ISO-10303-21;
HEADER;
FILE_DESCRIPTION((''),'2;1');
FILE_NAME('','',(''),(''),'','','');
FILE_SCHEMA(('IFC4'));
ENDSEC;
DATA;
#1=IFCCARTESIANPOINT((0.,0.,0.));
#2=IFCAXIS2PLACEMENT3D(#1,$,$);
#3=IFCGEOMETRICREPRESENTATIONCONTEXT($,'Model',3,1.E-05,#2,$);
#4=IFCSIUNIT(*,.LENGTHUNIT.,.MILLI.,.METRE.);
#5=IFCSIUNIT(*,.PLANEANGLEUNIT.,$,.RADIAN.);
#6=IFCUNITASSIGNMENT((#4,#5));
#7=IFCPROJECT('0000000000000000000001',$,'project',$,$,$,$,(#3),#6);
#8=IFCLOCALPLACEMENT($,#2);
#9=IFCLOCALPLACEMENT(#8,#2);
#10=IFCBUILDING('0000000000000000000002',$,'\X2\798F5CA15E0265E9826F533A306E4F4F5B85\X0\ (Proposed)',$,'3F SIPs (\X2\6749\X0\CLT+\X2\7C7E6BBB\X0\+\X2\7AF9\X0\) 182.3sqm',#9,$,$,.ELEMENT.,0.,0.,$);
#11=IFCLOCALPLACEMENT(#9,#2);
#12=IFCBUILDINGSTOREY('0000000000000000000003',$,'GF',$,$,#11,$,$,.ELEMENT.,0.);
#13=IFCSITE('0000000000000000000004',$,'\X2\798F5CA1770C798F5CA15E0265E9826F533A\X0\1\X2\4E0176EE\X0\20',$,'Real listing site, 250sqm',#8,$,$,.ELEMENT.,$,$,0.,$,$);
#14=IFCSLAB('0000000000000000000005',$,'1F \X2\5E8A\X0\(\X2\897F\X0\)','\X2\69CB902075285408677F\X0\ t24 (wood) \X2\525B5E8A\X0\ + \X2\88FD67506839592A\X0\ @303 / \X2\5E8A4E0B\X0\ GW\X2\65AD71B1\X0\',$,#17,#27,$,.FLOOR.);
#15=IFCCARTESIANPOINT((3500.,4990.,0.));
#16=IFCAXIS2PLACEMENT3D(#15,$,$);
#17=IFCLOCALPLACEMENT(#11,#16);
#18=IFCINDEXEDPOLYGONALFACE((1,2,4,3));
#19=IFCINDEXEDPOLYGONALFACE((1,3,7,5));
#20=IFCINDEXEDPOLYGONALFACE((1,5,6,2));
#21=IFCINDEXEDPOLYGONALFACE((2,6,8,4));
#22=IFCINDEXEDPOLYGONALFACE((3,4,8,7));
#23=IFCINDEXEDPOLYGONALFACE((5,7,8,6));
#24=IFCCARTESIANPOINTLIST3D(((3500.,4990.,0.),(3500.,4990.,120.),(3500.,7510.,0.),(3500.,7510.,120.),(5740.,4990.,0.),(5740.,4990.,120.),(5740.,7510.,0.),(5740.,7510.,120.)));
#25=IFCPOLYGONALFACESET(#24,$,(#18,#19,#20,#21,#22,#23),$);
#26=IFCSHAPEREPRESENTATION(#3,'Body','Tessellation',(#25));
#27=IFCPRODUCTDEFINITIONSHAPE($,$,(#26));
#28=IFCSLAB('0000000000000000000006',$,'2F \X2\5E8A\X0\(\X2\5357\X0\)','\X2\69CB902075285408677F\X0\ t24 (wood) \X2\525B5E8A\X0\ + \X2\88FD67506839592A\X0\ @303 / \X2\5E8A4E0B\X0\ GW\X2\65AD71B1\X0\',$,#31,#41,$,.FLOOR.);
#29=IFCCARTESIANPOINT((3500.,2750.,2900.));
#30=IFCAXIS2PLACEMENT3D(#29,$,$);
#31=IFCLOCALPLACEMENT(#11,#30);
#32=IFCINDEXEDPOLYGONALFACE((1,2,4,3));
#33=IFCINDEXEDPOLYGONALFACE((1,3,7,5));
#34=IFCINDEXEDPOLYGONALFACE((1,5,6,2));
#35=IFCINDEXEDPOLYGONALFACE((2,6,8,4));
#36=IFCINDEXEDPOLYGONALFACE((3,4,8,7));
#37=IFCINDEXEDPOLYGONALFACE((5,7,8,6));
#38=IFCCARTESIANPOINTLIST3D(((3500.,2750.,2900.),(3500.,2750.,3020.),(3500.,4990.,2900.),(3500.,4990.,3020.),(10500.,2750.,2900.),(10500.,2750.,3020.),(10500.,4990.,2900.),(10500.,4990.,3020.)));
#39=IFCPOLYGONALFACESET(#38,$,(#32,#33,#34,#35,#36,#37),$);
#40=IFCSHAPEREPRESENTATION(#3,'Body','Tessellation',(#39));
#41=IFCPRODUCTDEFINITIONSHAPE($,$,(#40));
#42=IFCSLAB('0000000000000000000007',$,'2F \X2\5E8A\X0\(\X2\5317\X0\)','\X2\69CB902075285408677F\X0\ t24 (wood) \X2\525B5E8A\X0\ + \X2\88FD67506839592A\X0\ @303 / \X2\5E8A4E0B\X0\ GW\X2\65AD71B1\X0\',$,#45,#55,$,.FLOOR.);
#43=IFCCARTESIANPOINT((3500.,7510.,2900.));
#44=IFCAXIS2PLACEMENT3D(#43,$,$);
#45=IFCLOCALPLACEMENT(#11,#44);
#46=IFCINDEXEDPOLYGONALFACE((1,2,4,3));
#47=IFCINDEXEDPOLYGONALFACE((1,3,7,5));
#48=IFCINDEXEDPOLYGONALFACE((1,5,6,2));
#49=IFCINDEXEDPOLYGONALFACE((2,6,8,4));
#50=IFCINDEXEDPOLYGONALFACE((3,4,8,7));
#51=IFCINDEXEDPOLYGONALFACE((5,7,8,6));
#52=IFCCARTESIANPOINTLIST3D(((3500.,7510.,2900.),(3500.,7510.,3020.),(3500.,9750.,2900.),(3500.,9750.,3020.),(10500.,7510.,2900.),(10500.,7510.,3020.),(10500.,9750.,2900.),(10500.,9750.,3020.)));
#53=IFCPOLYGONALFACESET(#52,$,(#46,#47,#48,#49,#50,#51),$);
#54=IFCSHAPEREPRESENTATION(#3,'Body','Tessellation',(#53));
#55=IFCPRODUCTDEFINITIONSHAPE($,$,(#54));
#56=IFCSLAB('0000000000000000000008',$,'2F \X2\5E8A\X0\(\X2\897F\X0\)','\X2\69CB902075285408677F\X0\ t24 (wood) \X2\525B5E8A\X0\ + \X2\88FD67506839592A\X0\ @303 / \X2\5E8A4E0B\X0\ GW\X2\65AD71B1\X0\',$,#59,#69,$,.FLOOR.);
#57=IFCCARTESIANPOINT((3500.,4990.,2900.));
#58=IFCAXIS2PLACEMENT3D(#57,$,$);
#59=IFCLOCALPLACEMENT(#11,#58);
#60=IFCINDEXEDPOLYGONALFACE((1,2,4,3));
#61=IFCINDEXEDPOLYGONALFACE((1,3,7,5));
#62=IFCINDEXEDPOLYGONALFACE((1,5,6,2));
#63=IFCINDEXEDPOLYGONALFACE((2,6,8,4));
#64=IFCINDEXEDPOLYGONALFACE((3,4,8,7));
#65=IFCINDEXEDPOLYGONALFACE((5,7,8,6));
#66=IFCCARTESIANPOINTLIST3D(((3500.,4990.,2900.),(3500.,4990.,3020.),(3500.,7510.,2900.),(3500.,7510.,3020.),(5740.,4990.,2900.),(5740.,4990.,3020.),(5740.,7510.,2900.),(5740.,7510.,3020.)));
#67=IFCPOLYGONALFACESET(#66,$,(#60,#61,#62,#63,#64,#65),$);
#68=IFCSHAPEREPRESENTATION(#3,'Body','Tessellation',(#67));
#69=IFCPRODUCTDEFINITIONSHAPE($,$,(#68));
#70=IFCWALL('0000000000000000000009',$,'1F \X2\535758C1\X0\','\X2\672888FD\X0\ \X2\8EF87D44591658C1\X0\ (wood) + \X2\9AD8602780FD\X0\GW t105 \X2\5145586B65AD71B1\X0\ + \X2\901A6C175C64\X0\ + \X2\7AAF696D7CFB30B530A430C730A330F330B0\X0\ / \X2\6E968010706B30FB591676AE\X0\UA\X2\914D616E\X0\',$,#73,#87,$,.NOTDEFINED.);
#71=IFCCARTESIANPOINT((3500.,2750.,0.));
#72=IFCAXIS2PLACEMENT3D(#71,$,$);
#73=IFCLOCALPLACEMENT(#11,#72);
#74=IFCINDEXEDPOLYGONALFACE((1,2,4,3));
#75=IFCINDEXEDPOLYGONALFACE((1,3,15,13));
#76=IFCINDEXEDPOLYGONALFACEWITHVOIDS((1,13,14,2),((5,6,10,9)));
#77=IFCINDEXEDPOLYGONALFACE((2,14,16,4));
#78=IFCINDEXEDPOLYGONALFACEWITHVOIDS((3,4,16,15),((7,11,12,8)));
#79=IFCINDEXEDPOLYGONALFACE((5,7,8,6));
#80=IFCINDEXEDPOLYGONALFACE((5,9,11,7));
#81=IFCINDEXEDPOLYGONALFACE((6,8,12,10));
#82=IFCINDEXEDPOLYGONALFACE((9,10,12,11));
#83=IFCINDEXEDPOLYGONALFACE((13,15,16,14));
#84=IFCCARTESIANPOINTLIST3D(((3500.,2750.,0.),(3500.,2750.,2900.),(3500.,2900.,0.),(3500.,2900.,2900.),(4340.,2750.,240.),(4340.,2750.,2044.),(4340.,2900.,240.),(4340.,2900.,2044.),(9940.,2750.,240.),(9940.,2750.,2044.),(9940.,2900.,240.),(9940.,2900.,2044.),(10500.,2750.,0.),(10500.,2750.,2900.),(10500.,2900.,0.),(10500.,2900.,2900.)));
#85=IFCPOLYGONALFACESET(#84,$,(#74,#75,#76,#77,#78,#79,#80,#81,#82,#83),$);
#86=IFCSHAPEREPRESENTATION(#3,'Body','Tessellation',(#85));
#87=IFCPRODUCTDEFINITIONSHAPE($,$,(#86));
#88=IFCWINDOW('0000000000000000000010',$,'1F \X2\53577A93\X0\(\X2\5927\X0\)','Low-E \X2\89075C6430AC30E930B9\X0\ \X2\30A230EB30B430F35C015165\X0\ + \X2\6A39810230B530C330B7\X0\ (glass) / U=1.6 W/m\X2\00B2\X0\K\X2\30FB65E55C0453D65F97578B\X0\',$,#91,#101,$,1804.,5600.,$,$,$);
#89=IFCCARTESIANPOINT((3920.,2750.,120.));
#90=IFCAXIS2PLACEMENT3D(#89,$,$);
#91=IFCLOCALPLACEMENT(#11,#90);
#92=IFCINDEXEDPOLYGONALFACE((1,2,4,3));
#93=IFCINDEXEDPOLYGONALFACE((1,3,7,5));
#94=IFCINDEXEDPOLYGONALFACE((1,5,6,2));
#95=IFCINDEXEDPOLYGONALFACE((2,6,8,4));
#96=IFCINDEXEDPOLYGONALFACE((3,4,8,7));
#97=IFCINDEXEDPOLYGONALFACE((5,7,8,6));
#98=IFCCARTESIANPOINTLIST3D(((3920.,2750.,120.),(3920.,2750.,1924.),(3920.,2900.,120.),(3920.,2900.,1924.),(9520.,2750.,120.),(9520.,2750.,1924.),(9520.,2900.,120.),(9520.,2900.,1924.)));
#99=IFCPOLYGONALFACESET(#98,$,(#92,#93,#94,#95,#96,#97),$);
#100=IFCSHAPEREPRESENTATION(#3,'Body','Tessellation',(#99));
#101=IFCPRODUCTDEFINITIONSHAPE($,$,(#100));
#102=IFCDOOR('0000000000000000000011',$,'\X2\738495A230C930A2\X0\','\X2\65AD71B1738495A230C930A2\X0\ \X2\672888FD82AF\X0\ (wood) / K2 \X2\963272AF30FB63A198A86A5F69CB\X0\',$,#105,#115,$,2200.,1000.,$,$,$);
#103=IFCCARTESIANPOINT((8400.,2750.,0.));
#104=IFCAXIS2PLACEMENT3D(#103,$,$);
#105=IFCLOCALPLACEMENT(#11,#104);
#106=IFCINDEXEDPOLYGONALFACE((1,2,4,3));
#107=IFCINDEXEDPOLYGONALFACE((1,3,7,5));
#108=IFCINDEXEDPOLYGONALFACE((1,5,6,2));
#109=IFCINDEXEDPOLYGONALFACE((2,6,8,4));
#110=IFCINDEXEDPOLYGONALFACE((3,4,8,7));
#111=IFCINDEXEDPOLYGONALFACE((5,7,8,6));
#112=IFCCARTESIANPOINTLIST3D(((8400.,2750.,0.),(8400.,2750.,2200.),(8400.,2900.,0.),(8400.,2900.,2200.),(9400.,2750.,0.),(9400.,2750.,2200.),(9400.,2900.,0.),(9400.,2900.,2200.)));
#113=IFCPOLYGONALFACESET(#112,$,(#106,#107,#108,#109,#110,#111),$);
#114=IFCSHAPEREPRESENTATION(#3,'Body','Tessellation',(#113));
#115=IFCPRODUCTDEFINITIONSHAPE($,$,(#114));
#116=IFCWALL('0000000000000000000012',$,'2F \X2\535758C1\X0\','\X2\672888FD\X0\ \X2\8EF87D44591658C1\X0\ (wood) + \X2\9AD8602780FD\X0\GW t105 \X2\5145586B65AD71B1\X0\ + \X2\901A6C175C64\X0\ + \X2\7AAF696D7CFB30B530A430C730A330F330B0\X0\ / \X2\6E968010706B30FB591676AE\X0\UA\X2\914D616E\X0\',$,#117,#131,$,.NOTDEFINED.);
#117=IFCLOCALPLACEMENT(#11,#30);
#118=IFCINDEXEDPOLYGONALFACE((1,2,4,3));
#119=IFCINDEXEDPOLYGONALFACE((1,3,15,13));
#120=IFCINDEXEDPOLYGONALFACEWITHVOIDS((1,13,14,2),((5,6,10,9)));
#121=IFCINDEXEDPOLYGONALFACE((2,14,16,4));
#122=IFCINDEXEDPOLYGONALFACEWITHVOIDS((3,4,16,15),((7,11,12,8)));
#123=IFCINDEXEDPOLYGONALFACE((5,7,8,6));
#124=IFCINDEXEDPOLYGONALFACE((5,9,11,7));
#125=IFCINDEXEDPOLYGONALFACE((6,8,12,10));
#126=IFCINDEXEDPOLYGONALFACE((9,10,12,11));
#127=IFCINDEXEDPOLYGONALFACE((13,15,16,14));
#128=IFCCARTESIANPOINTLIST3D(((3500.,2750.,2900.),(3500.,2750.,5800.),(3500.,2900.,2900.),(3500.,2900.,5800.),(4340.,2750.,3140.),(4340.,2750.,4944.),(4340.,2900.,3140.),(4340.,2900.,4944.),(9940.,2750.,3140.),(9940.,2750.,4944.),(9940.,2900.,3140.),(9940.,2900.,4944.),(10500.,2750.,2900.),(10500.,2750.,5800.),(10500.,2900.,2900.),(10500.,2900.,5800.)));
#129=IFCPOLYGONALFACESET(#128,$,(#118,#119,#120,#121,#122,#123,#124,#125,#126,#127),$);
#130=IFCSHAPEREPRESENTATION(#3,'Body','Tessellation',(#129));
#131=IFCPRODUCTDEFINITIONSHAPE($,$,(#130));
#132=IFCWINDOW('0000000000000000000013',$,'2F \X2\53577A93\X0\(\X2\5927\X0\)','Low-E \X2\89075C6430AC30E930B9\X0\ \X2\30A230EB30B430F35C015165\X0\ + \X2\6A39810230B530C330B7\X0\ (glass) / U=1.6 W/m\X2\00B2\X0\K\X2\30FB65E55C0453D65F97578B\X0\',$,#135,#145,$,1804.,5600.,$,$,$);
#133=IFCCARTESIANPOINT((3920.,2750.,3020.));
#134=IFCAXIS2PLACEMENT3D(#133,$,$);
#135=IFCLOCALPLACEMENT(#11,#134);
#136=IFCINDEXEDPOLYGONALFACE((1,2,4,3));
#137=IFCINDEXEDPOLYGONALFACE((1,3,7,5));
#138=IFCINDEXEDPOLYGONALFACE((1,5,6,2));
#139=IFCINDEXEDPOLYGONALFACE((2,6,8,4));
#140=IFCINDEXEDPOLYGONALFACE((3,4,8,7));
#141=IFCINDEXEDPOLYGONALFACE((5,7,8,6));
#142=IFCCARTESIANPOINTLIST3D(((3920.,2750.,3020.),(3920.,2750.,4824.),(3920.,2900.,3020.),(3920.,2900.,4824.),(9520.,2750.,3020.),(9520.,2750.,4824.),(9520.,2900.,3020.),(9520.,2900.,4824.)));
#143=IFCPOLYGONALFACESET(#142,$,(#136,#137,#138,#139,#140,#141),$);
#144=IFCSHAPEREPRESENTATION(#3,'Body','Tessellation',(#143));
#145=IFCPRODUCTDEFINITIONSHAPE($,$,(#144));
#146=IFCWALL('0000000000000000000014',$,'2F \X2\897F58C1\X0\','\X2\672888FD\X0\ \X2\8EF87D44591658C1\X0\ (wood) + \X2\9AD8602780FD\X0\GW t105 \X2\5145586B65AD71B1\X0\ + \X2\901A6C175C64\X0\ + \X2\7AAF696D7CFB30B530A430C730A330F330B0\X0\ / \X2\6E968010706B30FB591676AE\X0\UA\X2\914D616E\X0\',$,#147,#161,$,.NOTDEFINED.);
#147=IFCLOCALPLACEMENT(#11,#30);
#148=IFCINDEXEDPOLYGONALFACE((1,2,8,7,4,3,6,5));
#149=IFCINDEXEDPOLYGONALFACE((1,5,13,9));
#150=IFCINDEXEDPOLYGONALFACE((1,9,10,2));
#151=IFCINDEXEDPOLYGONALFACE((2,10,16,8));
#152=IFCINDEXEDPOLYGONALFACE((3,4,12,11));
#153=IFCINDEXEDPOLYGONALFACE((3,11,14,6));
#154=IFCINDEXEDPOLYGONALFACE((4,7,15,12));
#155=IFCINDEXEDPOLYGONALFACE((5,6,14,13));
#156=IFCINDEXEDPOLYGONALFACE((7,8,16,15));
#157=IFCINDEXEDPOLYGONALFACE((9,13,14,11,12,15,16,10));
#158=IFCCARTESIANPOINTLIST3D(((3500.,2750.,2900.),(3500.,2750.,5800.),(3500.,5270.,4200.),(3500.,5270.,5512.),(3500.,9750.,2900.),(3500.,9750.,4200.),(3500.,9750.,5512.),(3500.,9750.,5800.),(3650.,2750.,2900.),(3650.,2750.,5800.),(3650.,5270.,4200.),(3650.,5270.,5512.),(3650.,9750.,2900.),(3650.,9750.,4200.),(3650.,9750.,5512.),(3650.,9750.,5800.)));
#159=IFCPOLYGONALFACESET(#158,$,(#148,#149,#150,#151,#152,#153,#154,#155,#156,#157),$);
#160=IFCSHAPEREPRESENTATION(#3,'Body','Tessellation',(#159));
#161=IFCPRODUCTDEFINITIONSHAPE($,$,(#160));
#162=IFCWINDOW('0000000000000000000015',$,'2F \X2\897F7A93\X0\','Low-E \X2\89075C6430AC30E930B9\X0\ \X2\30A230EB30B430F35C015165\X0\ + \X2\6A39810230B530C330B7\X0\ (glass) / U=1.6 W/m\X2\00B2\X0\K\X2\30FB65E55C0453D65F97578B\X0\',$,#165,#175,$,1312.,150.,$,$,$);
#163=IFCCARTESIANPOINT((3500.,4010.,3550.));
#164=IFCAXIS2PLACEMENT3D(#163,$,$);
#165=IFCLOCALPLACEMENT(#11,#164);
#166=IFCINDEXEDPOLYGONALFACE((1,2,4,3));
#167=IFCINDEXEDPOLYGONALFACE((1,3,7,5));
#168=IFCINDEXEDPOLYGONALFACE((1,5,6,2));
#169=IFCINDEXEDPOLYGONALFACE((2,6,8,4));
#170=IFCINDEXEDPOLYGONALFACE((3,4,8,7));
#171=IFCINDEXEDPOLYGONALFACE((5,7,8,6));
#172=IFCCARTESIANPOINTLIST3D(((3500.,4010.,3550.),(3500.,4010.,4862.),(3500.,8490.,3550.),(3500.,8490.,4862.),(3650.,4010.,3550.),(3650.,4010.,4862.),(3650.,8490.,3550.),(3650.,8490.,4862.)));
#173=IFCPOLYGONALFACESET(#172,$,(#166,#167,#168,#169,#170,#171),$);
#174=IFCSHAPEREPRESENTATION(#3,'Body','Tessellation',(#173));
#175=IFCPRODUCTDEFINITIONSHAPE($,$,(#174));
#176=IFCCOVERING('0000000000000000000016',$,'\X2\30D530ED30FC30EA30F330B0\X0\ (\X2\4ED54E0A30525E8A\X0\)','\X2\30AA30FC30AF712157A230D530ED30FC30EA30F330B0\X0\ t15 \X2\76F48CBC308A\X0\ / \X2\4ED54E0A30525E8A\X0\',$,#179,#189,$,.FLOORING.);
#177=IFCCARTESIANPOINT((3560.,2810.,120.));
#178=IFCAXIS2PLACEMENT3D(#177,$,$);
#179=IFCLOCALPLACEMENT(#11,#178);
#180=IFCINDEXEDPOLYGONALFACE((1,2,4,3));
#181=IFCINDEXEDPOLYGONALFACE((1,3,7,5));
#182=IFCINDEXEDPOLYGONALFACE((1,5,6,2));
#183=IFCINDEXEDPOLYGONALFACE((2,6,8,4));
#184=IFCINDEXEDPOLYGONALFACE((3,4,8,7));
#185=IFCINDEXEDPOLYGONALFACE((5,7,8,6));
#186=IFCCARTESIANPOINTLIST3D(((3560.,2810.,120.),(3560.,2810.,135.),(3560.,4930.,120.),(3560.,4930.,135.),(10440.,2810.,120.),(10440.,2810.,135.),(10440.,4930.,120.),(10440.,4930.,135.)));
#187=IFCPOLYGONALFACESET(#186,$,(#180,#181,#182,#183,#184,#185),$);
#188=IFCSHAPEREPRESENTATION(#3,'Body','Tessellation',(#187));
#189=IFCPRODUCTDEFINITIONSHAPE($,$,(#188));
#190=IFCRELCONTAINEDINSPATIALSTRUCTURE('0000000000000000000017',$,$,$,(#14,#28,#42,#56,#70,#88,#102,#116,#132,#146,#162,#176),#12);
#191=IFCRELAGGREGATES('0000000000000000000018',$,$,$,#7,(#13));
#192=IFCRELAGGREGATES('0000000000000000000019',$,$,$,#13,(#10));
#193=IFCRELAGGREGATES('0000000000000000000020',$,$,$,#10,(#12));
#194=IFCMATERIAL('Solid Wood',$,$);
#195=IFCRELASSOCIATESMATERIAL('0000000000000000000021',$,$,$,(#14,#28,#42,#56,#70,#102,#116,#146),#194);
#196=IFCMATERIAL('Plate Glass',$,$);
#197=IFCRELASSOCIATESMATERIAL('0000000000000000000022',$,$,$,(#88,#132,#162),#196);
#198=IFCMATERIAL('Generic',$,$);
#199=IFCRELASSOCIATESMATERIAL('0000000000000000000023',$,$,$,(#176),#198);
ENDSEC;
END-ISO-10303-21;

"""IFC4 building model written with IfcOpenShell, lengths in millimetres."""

from ifc_helpers import new_model, si_unit, frame, frame_2d, origin, place, context, project, spatial, rectangle, extrude, material, element, fill, save


model = new_model("IFC4")

# Units and contexts
model_context = context("Model", 3, precision=1e-05, world=origin())
ifc_project = project(units=[si_unit("LENGTHUNIT", "METRE", prefix="MILLI"), si_unit("PLANEANGLEUNIT", "RADIAN")], contexts=[model_context])

# Site, building, storey
site_placement = place(None, origin())
site = spatial("IfcSite", under=ifc_project, at=site_placement, Name="福岡県福岡市早良区1丁目20", ObjectType="Real listing site, 250sqm", CompositionType="ELEMENT", RefElevation=0.0)
building_placement = place(site_placement, origin())
building = spatial("IfcBuilding", under=site, at=building_placement, Name="福岡市早良区の住宅 (Proposed)", ObjectType="3F SIPs (杉CLT+籾殻+竹) 182.3sqm", CompositionType="ELEMENT", ElevationOfRefHeight=0.0, ElevationOfTerrain=0.0)
storey_placement = place(building_placement, origin())
storey = spatial("IfcBuildingStorey", under=building, at=storey_placement, Name="GF", CompositionType="ELEMENT", Elevation=0.0)

# Slabs
ifc_material_1 = material(Name="Solid Wood")
slab_1_placement = place(storey_placement, frame((3500.0, 4990.0, 0.0)))
element("IfcSlab", 1, at=slab_1_placement, inside=storey, material=ifc_material_1, Name="1F 床(西)", Description="構造用合板 t24 (wood) 剛床 + 製材根太 @303 / 床下 GW断熱", PredefinedType="FLOOR", context=model_context, shape_type="SweptSolid", body=[
    extrude(rectangle(XDim=2240.0, YDim=2520.0, at=frame_2d((1120.0, 1260.0))), frame((3500.0, 4990.0, 0.0)), (0.0, 0.0, 1.0), 120.0),
])
slab_2_placement = place(storey_placement, frame((3500.0, 2750.0, 2900.0)))
element("IfcSlab", 2, at=slab_2_placement, inside=storey, material=ifc_material_1, Name="2F 床(南)", Description="構造用合板 t24 (wood) 剛床 + 製材根太 @303 / 床下 GW断熱", PredefinedType="FLOOR", context=model_context, shape_type="SweptSolid", body=[
    extrude(rectangle(XDim=7000.0, YDim=2240.0, at=frame_2d((3500.0, 1120.0))), frame((3500.0, 2750.0, 2900.0)), (0.0, 0.0, 1.0), 120.0),
])
slab_3_placement = place(storey_placement, frame((3500.0, 7510.0, 2900.0)))
element("IfcSlab", 3, at=slab_3_placement, inside=storey, material=ifc_material_1, Name="2F 床(北)", Description="構造用合板 t24 (wood) 剛床 + 製材根太 @303 / 床下 GW断熱", PredefinedType="FLOOR", context=model_context, shape_type="SweptSolid", body=[
    extrude(rectangle(XDim=7000.0, YDim=2240.0, at=frame_2d((3500.0, 1120.0))), frame((3500.0, 7510.0, 2900.0)), (0.0, 0.0, 1.0), 120.0),
])
slab_4_placement = place(storey_placement, frame((3500.0, 4990.0, 2900.0)))
element("IfcSlab", 4, at=slab_4_placement, inside=storey, material=ifc_material_1, Name="2F 床(西)", Description="構造用合板 t24 (wood) 剛床 + 製材根太 @303 / 床下 GW断熱", PredefinedType="FLOOR", context=model_context, shape_type="SweptSolid", body=[
    extrude(rectangle(XDim=2240.0, YDim=2520.0, at=frame_2d((1120.0, 1260.0))), frame((3500.0, 4990.0, 2900.0)), (0.0, 0.0, 1.0), 120.0),
])

# Wall, openings, window, door
wall_1_placement = place(storey_placement, frame((3500.0, 2750.0, 0.0)))
wall_1 = element("IfcWall", 5, at=wall_1_placement, inside=storey, material=ifc_material_1, Name="1F 南壁", Description="木製 軸組外壁 (wood) + 高性能GW t105 充填断熱 + 通気層 + 窯業系サイディング / 準耐火・外皮UA配慮", PredefinedType="NOTDEFINED", context=model_context, shape_type="SweptSolid", body=[
    extrude(rectangle(XDim=7000.0, YDim=150.0, at=frame_2d((3500.0, 75.0))), frame((3500.0, 2750.0, 0.0)), (0.0, 0.0, 1.0), 2900.0),
])
opening_1_placement = place(storey_placement, frame((3920.0, 2750.0, 120.0)))
opening_1 = element("IfcOpeningElement", 6, at=opening_1_placement, cuts=wall_1, PredefinedType="NOTDEFINED", context=model_context, shape_type="SweptSolid", body=[
    extrude(rectangle(XDim=5600.0, YDim=150.0, at=frame_2d((2800.0, 75.0))), frame((3920.0, 2750.0, 120.0)), (0.0, 0.0, 1.0), 1804.0),
])
opening_2_placement = place(storey_placement, frame((8400.0, 2750.0, 0.0)))
opening_2 = element("IfcOpeningElement", 7, at=opening_2_placement, cuts=wall_1, PredefinedType="NOTDEFINED", context=model_context, shape_type="SweptSolid", body=[
    extrude(rectangle(XDim=1000.0, YDim=150.0, at=frame_2d((500.0, 75.0))), frame((8400.0, 2750.0, 0.0)), (0.0, 0.0, 1.0), 2200.0),
])
ifc_material_2 = material(Name="Plate Glass")
window_1_placement = place(storey_placement, frame((3920.0, 2750.0, 120.0)))
window_1 = element("IfcWindow", 8, at=window_1_placement, inside=storey, material=ifc_material_2, Name="1F 南窓(大)", Description="Low-E 複層ガラス アルゴン封入 + 樹脂サッシ (glass) / U=1.6 W/m²K・日射取得型", OverallHeight=1804.0, OverallWidth=5600.0, context=model_context, shape_type="SweptSolid", body=[
    extrude(rectangle(XDim=5600.0, YDim=150.0, at=frame_2d((2800.0, 75.0))), frame((3920.0, 2750.0, 120.0)), (0.0, 0.0, 1.0), 1804.0),
])
fill(opening_1, window_1)
door_placement = place(storey_placement, frame((8400.0, 2750.0, 0.0)))
door = element("IfcDoor", 9, at=door_placement, inside=storey, material=ifc_material_1, Name="玄関ドア", Description="断熱玄関ドア 木製芯 (wood) / K2 防犯・採風機構", OverallHeight=2200.0, OverallWidth=1000.0, context=model_context, shape_type="SweptSolid", body=[
    extrude(rectangle(XDim=1000.0, YDim=150.0, at=frame_2d((500.0, 75.0))), frame((8400.0, 2750.0, 0.0)), (0.0, 0.0, 1.0), 2200.0),
])
fill(opening_2, door)

# Wall, opening, window
wall_2_placement = place(storey_placement, frame((3500.0, 2750.0, 2900.0)))
wall_2 = element("IfcWall", 10, at=wall_2_placement, inside=storey, material=ifc_material_1, Name="2F 南壁", Description="木製 軸組外壁 (wood) + 高性能GW t105 充填断熱 + 通気層 + 窯業系サイディング / 準耐火・外皮UA配慮", PredefinedType="NOTDEFINED", context=model_context, shape_type="SweptSolid", body=[
    extrude(rectangle(XDim=7000.0, YDim=150.0, at=frame_2d((3500.0, 75.0))), frame((3500.0, 2750.0, 2900.0)), (0.0, 0.0, 1.0), 2900.0),
])
opening_3_placement = place(storey_placement, frame((3920.0, 2750.0, 3020.0)))
opening_3 = element("IfcOpeningElement", 11, at=opening_3_placement, cuts=wall_2, PredefinedType="NOTDEFINED", context=model_context, shape_type="SweptSolid", body=[
    extrude(rectangle(XDim=5600.0, YDim=150.0, at=frame_2d((2800.0, 75.0))), frame((3920.0, 2750.0, 3020.0)), (0.0, 0.0, 1.0), 1804.0),
])
window_2_placement = place(storey_placement, frame((3920.0, 2750.0, 3020.0)))
window_2 = element("IfcWindow", 12, at=window_2_placement, inside=storey, material=ifc_material_2, Name="2F 南窓(大)", Description="Low-E 複層ガラス アルゴン封入 + 樹脂サッシ (glass) / U=1.6 W/m²K・日射取得型", OverallHeight=1804.0, OverallWidth=5600.0, context=model_context, shape_type="SweptSolid", body=[
    extrude(rectangle(XDim=5600.0, YDim=150.0, at=frame_2d((2800.0, 75.0))), frame((3920.0, 2750.0, 3020.0)), (0.0, 0.0, 1.0), 1804.0),
])
fill(opening_3, window_2)

# Wall, opening, window
wall_3_placement = place(storey_placement, frame((3500.0, 2750.0, 2900.0)))
wall_3 = element("IfcWall", 13, at=wall_3_placement, inside=storey, material=ifc_material_1, Name="2F 西壁", Description="木製 軸組外壁 (wood) + 高性能GW t105 充填断熱 + 通気層 + 窯業系サイディング / 準耐火・外皮UA配慮", PredefinedType="NOTDEFINED", context=model_context, shape_type="SweptSolid", body=[
    extrude(rectangle(XDim=150.0, YDim=7000.0, at=frame_2d((75.0, 3500.0))), frame((3500.0, 2750.0, 2900.0)), (0.0, 0.0, 1.0), 2900.0),
])
opening_4_placement = place(storey_placement, frame((3500.0, 4010.0, 3550.0)))
opening_4 = element("IfcOpeningElement", 14, at=opening_4_placement, cuts=wall_3, PredefinedType="NOTDEFINED", context=model_context, shape_type="SweptSolid", body=[
    extrude(rectangle(XDim=150.0, YDim=4480.0, at=frame_2d((75.0, 2240.0))), frame((3500.0, 4010.0, 3550.0)), (0.0, 0.0, 1.0), 1312.0),
])
window_3_placement = place(storey_placement, frame((3500.0, 4010.0, 3550.0)))
window_3 = element("IfcWindow", 15, at=window_3_placement, inside=storey, material=ifc_material_2, Name="2F 西窓", Description="Low-E 複層ガラス アルゴン封入 + 樹脂サッシ (glass) / U=1.6 W/m²K・日射取得型", OverallHeight=1312.0, OverallWidth=150.0, context=model_context, shape_type="SweptSolid", body=[
    extrude(rectangle(XDim=150.0, YDim=4480.0, at=frame_2d((75.0, 2240.0))), frame((3500.0, 4010.0, 3550.0)), (0.0, 0.0, 1.0), 1312.0),
])
fill(opening_4, window_3)

# Covering
ifc_material_3 = material(Name="Generic")
covering_1_placement = place(storey_placement, frame((3560.0, 2810.0, 120.0)))
element("IfcCovering", 16, at=covering_1_placement, inside=storey, material=ifc_material_3, Name="フローリング (仕上げ床)", Description="オーク無垢フローリング t15 直貼り / 仕上げ床", PredefinedType="FLOORING", context=model_context, shape_type="SweptSolid", body=[
    extrude(rectangle(XDim=6880.0, YDim=2120.0, at=frame_2d((3440.0, 1060.0))), frame((3560.0, 2810.0, 120.0)), (0.0, 0.0, 1.0), 15.0),
])

save(model, "model.ifc")
